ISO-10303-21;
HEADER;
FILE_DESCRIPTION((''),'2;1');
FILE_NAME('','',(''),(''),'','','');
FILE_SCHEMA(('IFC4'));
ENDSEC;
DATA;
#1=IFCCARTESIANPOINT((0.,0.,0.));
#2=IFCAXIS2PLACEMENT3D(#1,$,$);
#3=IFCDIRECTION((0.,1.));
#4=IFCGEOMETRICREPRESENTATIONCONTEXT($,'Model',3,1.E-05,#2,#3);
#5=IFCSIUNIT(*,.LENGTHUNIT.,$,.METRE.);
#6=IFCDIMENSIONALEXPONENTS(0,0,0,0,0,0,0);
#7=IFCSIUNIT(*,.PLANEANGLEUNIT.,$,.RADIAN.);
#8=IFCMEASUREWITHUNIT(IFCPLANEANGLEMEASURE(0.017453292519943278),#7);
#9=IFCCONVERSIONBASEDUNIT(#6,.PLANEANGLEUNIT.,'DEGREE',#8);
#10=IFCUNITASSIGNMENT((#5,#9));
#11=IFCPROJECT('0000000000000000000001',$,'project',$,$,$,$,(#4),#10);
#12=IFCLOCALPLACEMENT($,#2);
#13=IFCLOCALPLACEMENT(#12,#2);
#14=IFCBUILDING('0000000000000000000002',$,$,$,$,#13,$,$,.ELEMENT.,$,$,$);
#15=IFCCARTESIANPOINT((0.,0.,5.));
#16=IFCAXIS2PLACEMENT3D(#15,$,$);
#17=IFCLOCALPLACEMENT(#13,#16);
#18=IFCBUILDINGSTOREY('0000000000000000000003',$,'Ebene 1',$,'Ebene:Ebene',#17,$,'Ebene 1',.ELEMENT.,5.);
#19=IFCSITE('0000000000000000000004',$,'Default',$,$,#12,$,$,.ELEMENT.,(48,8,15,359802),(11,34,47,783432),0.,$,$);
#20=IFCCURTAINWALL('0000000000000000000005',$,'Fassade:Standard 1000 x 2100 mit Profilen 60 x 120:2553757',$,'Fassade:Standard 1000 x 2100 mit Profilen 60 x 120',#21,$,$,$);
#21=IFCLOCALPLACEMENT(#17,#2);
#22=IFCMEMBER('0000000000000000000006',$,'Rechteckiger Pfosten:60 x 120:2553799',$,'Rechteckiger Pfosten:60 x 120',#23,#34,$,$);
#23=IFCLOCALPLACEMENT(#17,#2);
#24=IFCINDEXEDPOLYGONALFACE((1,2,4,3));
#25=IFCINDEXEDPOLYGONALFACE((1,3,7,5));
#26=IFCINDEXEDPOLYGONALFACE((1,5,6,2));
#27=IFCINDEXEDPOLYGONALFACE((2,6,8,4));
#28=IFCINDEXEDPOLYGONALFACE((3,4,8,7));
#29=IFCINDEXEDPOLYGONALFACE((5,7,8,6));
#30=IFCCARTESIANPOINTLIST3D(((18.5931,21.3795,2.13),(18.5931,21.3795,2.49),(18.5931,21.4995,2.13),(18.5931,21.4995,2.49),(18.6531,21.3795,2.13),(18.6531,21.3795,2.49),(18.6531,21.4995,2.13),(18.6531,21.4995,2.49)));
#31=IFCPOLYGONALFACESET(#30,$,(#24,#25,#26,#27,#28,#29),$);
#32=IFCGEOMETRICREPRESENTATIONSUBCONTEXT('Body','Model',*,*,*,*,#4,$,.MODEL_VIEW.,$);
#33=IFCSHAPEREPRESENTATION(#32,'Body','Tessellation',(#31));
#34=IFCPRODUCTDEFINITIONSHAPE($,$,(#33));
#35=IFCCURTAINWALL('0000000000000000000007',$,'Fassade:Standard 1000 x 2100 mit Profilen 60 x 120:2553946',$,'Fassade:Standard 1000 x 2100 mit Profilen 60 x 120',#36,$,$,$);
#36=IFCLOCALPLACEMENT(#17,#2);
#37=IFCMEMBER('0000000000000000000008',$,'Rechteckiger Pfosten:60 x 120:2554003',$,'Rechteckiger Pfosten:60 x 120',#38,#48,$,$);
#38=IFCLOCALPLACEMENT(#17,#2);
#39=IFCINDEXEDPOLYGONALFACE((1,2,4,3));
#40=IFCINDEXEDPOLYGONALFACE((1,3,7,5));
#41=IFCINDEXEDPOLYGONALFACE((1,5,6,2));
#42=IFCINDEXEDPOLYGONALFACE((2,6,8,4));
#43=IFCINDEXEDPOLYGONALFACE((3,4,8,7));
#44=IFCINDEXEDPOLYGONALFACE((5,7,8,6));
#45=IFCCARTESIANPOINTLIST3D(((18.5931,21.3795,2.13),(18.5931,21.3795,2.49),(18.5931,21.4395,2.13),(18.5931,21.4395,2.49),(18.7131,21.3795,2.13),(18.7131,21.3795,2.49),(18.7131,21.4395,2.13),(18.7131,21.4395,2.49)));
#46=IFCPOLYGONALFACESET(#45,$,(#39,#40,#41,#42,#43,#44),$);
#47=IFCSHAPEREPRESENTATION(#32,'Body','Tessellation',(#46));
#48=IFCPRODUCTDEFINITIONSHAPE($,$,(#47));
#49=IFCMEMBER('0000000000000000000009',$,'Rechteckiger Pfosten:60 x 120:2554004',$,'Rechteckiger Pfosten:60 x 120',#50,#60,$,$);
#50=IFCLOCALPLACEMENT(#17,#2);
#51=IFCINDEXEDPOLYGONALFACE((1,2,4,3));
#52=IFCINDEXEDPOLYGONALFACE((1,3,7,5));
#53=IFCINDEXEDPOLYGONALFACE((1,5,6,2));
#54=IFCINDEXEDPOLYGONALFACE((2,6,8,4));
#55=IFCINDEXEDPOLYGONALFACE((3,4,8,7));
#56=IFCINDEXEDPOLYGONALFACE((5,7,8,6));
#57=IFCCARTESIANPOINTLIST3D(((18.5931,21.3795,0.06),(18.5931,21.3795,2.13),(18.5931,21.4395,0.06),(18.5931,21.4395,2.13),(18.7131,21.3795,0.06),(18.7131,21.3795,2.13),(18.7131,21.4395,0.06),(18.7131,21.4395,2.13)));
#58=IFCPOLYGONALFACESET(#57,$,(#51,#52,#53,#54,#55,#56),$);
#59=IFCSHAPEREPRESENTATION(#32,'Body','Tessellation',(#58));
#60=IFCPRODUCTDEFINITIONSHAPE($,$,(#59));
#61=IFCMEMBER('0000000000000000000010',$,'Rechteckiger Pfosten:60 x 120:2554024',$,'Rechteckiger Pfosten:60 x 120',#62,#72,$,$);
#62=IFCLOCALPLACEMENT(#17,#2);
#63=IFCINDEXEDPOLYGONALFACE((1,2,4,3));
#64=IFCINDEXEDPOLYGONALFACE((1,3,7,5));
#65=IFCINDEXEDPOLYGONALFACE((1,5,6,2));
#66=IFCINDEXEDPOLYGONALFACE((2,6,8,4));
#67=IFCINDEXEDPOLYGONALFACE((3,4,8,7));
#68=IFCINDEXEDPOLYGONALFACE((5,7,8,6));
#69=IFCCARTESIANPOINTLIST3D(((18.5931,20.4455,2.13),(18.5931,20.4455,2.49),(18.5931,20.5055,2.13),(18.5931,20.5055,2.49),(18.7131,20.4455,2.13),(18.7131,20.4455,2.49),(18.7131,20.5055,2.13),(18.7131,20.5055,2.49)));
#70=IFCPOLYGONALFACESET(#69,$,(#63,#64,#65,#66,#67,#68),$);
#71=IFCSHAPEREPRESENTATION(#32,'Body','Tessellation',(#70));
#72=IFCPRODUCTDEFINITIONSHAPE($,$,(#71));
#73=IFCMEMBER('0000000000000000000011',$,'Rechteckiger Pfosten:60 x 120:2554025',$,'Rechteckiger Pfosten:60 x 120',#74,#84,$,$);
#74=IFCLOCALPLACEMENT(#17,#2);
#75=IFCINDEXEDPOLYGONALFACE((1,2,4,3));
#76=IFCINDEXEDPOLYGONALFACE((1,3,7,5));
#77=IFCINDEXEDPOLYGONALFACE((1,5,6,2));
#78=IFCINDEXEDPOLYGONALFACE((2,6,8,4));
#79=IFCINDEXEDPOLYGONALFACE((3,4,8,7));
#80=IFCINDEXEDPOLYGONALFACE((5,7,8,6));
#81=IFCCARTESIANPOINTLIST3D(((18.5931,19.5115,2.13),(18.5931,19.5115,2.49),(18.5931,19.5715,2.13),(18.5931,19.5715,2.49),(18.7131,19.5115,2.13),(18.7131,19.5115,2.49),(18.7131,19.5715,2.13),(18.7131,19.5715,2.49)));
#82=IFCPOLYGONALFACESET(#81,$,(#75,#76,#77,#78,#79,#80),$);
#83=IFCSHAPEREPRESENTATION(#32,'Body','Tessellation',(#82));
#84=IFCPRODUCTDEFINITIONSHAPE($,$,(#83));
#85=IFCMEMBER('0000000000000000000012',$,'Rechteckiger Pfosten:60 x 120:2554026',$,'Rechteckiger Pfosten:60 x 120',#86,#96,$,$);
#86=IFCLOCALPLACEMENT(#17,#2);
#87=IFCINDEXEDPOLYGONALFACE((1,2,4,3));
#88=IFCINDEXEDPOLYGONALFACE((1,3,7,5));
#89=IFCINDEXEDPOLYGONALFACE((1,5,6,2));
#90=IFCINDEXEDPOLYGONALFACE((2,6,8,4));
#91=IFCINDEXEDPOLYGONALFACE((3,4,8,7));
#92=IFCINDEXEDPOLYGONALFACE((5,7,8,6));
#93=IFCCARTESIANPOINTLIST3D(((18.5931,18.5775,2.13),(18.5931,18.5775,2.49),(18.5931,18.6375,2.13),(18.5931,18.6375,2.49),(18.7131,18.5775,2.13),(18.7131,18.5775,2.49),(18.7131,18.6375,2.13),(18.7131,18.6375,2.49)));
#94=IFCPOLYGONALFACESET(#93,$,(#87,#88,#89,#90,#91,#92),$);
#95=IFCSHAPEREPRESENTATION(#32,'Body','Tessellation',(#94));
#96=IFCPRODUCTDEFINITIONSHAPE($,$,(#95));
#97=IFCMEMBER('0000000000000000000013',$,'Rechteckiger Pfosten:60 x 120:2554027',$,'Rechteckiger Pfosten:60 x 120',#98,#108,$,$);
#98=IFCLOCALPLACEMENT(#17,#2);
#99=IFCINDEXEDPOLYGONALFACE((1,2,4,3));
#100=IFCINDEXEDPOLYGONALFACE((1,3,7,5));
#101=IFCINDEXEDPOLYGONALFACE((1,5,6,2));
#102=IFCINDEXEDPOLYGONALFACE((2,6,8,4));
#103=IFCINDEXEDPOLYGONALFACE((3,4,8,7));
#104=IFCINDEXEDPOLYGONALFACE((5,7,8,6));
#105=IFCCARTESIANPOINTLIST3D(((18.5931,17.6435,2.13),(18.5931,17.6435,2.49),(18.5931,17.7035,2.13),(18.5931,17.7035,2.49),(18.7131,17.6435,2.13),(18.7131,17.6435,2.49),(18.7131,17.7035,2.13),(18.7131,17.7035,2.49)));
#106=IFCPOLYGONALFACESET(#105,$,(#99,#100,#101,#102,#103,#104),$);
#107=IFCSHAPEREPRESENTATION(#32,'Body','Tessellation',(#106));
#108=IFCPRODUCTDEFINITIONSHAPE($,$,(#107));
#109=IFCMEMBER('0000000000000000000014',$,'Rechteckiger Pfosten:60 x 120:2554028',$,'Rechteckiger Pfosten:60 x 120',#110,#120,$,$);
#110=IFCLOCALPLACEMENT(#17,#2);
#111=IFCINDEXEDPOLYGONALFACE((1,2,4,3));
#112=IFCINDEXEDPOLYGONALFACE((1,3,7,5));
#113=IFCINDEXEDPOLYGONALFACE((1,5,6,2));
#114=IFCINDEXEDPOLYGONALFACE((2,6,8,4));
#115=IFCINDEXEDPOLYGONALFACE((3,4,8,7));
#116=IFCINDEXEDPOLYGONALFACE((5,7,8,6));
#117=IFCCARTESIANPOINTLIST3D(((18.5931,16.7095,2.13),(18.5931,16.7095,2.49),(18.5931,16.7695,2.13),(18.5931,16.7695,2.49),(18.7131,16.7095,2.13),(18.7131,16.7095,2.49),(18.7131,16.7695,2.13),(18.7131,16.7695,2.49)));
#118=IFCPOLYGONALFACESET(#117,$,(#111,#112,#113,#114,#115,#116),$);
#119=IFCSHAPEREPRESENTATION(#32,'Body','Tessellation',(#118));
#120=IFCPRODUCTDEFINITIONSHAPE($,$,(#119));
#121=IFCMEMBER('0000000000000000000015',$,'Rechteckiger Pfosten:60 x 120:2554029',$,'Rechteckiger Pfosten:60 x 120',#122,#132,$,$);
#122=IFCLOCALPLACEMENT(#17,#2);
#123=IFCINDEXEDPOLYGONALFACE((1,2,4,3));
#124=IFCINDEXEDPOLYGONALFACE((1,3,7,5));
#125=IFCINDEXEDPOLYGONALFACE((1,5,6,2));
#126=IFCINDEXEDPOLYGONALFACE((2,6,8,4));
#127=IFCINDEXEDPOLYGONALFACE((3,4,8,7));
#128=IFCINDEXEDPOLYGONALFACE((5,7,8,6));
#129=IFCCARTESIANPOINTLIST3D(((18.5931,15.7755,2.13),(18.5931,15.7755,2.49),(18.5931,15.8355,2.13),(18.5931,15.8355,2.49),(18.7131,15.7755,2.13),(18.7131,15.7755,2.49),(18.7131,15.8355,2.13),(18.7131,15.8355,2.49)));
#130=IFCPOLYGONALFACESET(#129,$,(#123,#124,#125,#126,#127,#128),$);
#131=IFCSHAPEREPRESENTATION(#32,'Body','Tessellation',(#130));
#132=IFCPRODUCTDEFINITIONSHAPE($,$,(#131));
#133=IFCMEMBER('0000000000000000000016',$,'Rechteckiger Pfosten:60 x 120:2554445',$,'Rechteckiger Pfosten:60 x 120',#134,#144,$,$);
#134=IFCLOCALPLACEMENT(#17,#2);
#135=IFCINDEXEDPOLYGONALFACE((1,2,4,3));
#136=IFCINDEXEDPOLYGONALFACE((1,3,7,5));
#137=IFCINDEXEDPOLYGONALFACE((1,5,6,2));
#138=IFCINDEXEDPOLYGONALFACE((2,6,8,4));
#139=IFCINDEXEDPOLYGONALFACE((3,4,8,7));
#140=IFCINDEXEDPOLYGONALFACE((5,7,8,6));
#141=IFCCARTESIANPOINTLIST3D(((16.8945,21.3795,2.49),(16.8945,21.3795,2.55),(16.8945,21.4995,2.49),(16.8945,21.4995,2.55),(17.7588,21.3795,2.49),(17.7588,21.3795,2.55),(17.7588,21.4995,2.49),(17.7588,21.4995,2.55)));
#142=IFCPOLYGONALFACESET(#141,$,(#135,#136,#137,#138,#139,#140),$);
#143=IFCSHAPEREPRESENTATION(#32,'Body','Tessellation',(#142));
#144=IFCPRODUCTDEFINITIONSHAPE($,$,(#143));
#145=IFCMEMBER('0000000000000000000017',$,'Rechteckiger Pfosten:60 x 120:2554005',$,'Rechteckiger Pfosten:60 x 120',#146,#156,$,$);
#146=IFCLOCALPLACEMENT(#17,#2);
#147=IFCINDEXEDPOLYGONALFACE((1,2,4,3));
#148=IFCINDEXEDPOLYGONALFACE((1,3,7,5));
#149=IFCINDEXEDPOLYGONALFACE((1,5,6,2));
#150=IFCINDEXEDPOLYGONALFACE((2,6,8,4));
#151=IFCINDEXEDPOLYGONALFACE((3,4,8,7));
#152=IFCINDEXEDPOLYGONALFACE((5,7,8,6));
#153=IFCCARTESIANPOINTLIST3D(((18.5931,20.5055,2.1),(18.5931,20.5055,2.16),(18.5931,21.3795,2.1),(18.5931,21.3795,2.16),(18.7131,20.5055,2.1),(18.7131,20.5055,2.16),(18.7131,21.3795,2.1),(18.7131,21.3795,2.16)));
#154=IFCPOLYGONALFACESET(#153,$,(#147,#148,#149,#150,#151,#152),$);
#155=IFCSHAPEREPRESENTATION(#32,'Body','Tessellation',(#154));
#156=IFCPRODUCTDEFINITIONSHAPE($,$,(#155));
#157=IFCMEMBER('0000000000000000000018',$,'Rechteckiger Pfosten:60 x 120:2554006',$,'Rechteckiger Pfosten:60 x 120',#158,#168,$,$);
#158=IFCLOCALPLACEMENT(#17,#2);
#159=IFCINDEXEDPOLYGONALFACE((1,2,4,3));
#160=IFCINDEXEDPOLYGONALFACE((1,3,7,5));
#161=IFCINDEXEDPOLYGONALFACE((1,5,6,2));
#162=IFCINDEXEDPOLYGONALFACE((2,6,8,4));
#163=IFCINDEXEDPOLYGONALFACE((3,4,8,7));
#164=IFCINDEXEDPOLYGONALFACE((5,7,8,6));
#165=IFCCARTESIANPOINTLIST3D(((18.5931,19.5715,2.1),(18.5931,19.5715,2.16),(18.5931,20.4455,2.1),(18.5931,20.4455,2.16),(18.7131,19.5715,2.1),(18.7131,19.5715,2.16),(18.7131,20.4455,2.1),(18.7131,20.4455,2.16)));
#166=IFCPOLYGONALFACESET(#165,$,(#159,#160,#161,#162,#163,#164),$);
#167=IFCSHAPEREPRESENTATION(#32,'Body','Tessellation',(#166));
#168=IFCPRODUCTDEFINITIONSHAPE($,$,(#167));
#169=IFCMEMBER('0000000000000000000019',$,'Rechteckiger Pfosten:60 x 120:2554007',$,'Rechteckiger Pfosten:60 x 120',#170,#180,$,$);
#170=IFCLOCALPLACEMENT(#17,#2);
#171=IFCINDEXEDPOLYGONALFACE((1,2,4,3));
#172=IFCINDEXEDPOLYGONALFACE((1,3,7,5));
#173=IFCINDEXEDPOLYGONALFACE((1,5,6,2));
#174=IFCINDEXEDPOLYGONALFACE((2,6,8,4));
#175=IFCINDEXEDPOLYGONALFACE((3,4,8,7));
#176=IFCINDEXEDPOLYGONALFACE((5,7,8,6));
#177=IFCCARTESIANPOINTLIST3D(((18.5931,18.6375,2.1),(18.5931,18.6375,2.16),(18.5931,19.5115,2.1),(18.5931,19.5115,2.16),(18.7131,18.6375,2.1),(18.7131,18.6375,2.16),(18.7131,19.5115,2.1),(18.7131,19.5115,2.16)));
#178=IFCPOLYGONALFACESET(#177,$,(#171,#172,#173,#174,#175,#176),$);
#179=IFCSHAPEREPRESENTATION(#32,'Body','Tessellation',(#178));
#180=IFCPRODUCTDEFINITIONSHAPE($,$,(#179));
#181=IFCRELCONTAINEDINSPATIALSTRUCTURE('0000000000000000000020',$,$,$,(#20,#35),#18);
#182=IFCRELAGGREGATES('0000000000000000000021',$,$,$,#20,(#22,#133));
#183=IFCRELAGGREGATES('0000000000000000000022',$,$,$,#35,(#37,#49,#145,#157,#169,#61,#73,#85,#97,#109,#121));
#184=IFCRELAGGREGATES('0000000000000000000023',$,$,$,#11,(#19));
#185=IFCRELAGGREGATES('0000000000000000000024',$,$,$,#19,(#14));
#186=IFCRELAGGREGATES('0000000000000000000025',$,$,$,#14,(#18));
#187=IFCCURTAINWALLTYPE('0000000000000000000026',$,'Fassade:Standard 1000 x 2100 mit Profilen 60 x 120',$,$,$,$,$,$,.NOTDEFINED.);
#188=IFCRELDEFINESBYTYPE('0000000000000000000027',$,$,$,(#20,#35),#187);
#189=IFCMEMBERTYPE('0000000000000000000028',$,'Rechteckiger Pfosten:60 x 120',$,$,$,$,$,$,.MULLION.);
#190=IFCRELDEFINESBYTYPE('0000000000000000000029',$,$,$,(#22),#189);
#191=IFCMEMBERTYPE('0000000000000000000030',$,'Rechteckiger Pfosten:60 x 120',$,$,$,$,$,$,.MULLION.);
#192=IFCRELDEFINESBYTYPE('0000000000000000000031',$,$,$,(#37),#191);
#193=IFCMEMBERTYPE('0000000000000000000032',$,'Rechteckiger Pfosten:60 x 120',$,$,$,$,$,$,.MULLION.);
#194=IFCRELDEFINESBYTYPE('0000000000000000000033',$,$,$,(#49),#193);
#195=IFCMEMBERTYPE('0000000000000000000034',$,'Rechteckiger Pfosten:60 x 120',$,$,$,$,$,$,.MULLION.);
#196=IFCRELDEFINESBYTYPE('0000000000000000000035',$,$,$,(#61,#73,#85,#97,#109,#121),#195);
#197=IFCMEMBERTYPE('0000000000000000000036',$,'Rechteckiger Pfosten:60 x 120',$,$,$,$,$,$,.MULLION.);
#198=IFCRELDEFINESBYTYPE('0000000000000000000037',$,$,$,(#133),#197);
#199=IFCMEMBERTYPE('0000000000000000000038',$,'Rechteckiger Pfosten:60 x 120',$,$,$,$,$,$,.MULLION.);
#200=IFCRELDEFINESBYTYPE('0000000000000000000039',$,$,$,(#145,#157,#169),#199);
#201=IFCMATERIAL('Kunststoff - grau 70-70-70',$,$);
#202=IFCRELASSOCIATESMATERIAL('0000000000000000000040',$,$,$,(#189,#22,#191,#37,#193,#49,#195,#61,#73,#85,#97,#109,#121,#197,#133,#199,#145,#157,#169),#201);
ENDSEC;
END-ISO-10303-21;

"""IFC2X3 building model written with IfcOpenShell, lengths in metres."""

from ifc_helpers import new_model, entity, si_unit, converted_unit, direction, frame, frame_2d, origin, origin_2d_with_axis, place, context, subcontext, project, spatial, rectangle, extrude, source, transform, mapped, material, type_object, type_shapes, element, aggregate, save


model = new_model("IFC2X3")

# Units and contexts
model_context = context("Model", 3, precision=1e-05, world=origin(), true_north=direction((0.0, 1.0)))
body_context = subcontext(model_context, "Body", "Model", "MODEL_VIEW")
ifc_project = project(units=[si_unit("LENGTHUNIT", "METRE"), converted_unit("PLANEANGLEUNIT", "DEGREE", entity("IfcPlaneAngleMeasure", 0.017453292519943278), si_unit("PLANEANGLEUNIT", "RADIAN"), dimensions=[0, 0, 0, 0, 0, 0, 0])], contexts=[model_context])

# Site, building, storey
site_placement = place(None, origin())
site = spatial("IfcSite", under=ifc_project, at=site_placement, Name="Default", CompositionType="ELEMENT", RefLatitude=(48, 8, 15, 359802), RefLongitude=(11, 34, 47, 783432), RefElevation=0.0)
building_placement = place(site_placement, origin())
building = spatial("IfcBuilding", under=site, at=building_placement, CompositionType="ELEMENT")
storey_placement = place(building_placement, frame((0.0, 0.0, 5.0)))
storey = spatial("IfcBuildingStorey", under=building, at=storey_placement, Name="Ebene 1", ObjectType="Ebene:Ebene", LongName="Ebene 1", CompositionType="ELEMENT", Elevation=5.0)

# Curtain wall, member
curtain_wall_type = type_object("IfcCurtainWallType", Name="Fassade:Standard 1000 x 2100 mit Profilen 60 x 120", PredefinedType="NOTDEFINED")
curtain_wall_1_placement = place(storey_placement, frame((0.0, 0.0, -5.0)))
curtain_wall_1 = element("IfcCurtainWall", 1, at=curtain_wall_1_placement, inside=storey, type_object=curtain_wall_type, Name="Fassade:Standard 1000 x 2100 mit Profilen 60 x 120:2553757", ObjectType="Fassade:Standard 1000 x 2100 mit Profilen 60 x 120")
ifc_material_1 = material(Name="Kunststoff - grau 70-70-70")
member_type_1 = type_object("IfcMemberType", Name="Rechteckiger Pfosten:60 x 120", PredefinedType="MULLION", material=ifc_material_1)
shared_shape_1 = source(origin(), body_context, "Body", "SweptSolid", [
    extrude(rectangle(XDim=0.06, YDim=0.12, at=origin_2d_with_axis()), frame((-0.03, 0.0, -0.36), z_axis=(0.0, 0.0, 1.0), x_axis=(-1.0, 0.0, 0.0)), (0.0, 0.0, 1.0), 0.36),
])
type_shapes(member_type_1, [shared_shape_1])
member_1_placement = place(curtain_wall_1_placement, frame((18.6531, 21.4395, 7.13), z_axis=(0.0, 0.0, -1.0), x_axis=(1.0, 0.0, 0.0)))
member_1 = element("IfcMember", 2, at=member_1_placement, type_object=member_type_1, material=ifc_material_1, Name="Rechteckiger Pfosten:60 x 120:2553799", ObjectType="Rechteckiger Pfosten:60 x 120", context=body_context, shape_type="MappedRepresentation", body=[
    mapped(shared_shape_1, transform((0.0, 0.0, 0.0), scale=1.0)),
])

# Curtain wall, members
curtain_wall_2_placement = place(storey_placement, frame((0.0, 0.0, -5.0)))
curtain_wall_2 = element("IfcCurtainWall", 3, at=curtain_wall_2_placement, inside=storey, type_object=curtain_wall_type, Name="Fassade:Standard 1000 x 2100 mit Profilen 60 x 120:2553946", ObjectType="Fassade:Standard 1000 x 2100 mit Profilen 60 x 120")
member_type_2 = type_object("IfcMemberType", Name="Rechteckiger Pfosten:60 x 120", PredefinedType="MULLION", material=ifc_material_1)
shared_shape_2 = source(origin(), body_context, "Body", "SweptSolid", [
    extrude(rectangle(XDim=0.06, YDim=0.12, at=origin_2d_with_axis()), frame((-0.03, 0.0, -0.36), z_axis=(0.0, 0.0, 1.0), x_axis=(-1.0, 0.0, 0.0)), (0.0, 0.0, 1.0), 0.36),
])
type_shapes(member_type_2, [shared_shape_2])
member_2_placement = place(curtain_wall_2_placement, frame((18.6531, 21.4395, 7.49), z_axis=(0.0, 0.0, 1.0), x_axis=(0.0, 1.0, 0.0)))
member_2 = element("IfcMember", 4, at=member_2_placement, type_object=member_type_2, material=ifc_material_1, Name="Rechteckiger Pfosten:60 x 120:2554003", ObjectType="Rechteckiger Pfosten:60 x 120", context=body_context, shape_type="MappedRepresentation", body=[
    mapped(shared_shape_2, transform((0.0, 0.0, 0.0), scale=1.0)),
])
member_type_3 = type_object("IfcMemberType", Name="Rechteckiger Pfosten:60 x 120", PredefinedType="MULLION", material=ifc_material_1)
shared_shape_3 = source(origin(), body_context, "Body", "SweptSolid", [
    extrude(rectangle(XDim=0.06, YDim=0.12, at=origin_2d_with_axis()), frame((-0.03, 0.0, -2.07), z_axis=(0.0, 0.0, 1.0), x_axis=(-1.0, 0.0, 0.0)), (0.0, 0.0, 1.0), 2.07),
])
type_shapes(member_type_3, [shared_shape_3])
member_3_placement = place(curtain_wall_2_placement, frame((18.6531, 21.4395, 7.13), z_axis=(0.0, 0.0, 1.0), x_axis=(0.0, 1.0, 0.0)))
member_3 = element("IfcMember", 5, at=member_3_placement, type_object=member_type_3, material=ifc_material_1, Name="Rechteckiger Pfosten:60 x 120:2554004", ObjectType="Rechteckiger Pfosten:60 x 120", context=body_context, shape_type="MappedRepresentation", body=[
    mapped(shared_shape_3, transform((0.0, 0.0, 0.0), scale=1.0)),
])
member_type_4 = type_object("IfcMemberType", Name="Rechteckiger Pfosten:60 x 120", PredefinedType="MULLION", material=ifc_material_1)
shared_shape_4 = source(origin(), body_context, "Body", "SweptSolid", [
    extrude(rectangle(XDim=0.06, YDim=0.12, at=frame_2d((0.0, 0.0), x_axis=(1.0, 0.0))), frame((0.0, 0.0, -0.36), z_axis=(0.0, 0.0, 1.0), x_axis=(-1.0, 0.0, 0.0)), (0.0, 0.0, 1.0), 0.36),
])
type_shapes(member_type_4, [shared_shape_4])
member_4_placement = place(curtain_wall_2_placement, frame((18.6531, 20.4755, 7.13), z_axis=(0.0, 0.0, -1.0), x_axis=(0.0, -1.0, 0.0)))
member_4 = element("IfcMember", 6, at=member_4_placement, type_object=member_type_4, material=ifc_material_1, Name="Rechteckiger Pfosten:60 x 120:2554024", ObjectType="Rechteckiger Pfosten:60 x 120", context=body_context, shape_type="MappedRepresentation", body=[
    mapped(shared_shape_4, transform((0.0, 0.0, 0.0), scale=1.0)),
])
member_5_placement = place(curtain_wall_2_placement, frame((18.6531, 19.5415, 7.13), z_axis=(0.0, 0.0, -1.0), x_axis=(0.0, -1.0, 0.0)))
member_5 = element("IfcMember", 7, at=member_5_placement, type_object=member_type_4, material=ifc_material_1, Name="Rechteckiger Pfosten:60 x 120:2554025", ObjectType="Rechteckiger Pfosten:60 x 120", context=body_context, shape_type="MappedRepresentation", body=[
    mapped(shared_shape_4, transform((0.0, 0.0, 0.0), scale=1.0)),
])
member_6_placement = place(curtain_wall_2_placement, frame((18.6531, 18.6075, 7.13), z_axis=(0.0, 0.0, -1.0), x_axis=(0.0, -1.0, 0.0)))
member_6 = element("IfcMember", 8, at=member_6_placement, type_object=member_type_4, material=ifc_material_1, Name="Rechteckiger Pfosten:60 x 120:2554026", ObjectType="Rechteckiger Pfosten:60 x 120", context=body_context, shape_type="MappedRepresentation", body=[
    mapped(shared_shape_4, transform((0.0, 0.0, 0.0), scale=1.0)),
])
member_7_placement = place(curtain_wall_2_placement, frame((18.6531, 17.6735, 7.13), z_axis=(0.0, 0.0, -1.0), x_axis=(0.0, -1.0, 0.0)))
member_7 = element("IfcMember", 9, at=member_7_placement, type_object=member_type_4, material=ifc_material_1, Name="Rechteckiger Pfosten:60 x 120:2554027", ObjectType="Rechteckiger Pfosten:60 x 120", context=body_context, shape_type="MappedRepresentation", body=[
    mapped(shared_shape_4, transform((0.0, 0.0, 0.0), scale=1.0)),
])
member_8_placement = place(curtain_wall_2_placement, frame((18.6531, 16.7395, 7.13), z_axis=(0.0, 0.0, -1.0), x_axis=(0.0, -1.0, 0.0)))
member_8 = element("IfcMember", 10, at=member_8_placement, type_object=member_type_4, material=ifc_material_1, Name="Rechteckiger Pfosten:60 x 120:2554028", ObjectType="Rechteckiger Pfosten:60 x 120", context=body_context, shape_type="MappedRepresentation", body=[
    mapped(shared_shape_4, transform((0.0, 0.0, 0.0), scale=1.0)),
])
member_9_placement = place(curtain_wall_2_placement, frame((18.6531, 15.8055, 7.13), z_axis=(0.0, 0.0, -1.0), x_axis=(0.0, -1.0, 0.0)))
member_9 = element("IfcMember", 11, at=member_9_placement, type_object=member_type_4, material=ifc_material_1, Name="Rechteckiger Pfosten:60 x 120:2554029", ObjectType="Rechteckiger Pfosten:60 x 120", context=body_context, shape_type="MappedRepresentation", body=[
    mapped(shared_shape_4, transform((0.0, 0.0, 0.0), scale=1.0)),
])

# Members
member_type_5 = type_object("IfcMemberType", Name="Rechteckiger Pfosten:60 x 120", PredefinedType="MULLION", material=ifc_material_1)
shared_shape_5 = source(origin(), body_context, "Body", "SweptSolid", [
    extrude(rectangle(XDim=0.06, YDim=0.12, at=origin_2d_with_axis()), frame((-0.03, 0.0, -0.8643), z_axis=(0.0, 0.0, 1.0), x_axis=(-1.0, 0.0, 0.0)), (0.0, 0.0, 1.0), 0.8643),
])
type_shapes(member_type_5, [shared_shape_5])
member_10_placement = place(curtain_wall_1_placement, frame((17.7588, 21.4395, 7.55), z_axis=(1.0, 0.0, 0.0), x_axis=(0.0, 0.0, 1.0)))
member_10 = element("IfcMember", 12, at=member_10_placement, type_object=member_type_5, material=ifc_material_1, Name="Rechteckiger Pfosten:60 x 120:2554445", ObjectType="Rechteckiger Pfosten:60 x 120", context=body_context, shape_type="MappedRepresentation", body=[
    mapped(shared_shape_5, transform((0.0, 0.0, 0.0), scale=1.0)),
])
member_type_6 = type_object("IfcMemberType", Name="Rechteckiger Pfosten:60 x 120", PredefinedType="MULLION", material=ifc_material_1)
shared_shape_6 = source(origin(), body_context, "Body", "SweptSolid", [
    extrude(rectangle(XDim=0.06, YDim=0.12, at=frame_2d((0.0, 0.0), x_axis=(1.0, 0.0))), frame((0.0, 0.0, -0.874), z_axis=(0.0, 0.0, 1.0), x_axis=(-1.0, 0.0, 0.0)), (0.0, 0.0, 1.0), 0.874),
])
type_shapes(member_type_6, [shared_shape_6])
member_11_placement = place(curtain_wall_2_placement, frame((18.6531, 20.5055, 7.13), z_axis=(0.0, -1.0, 0.0), x_axis=(0.0, 0.0, 1.0)))
member_11 = element("IfcMember", 13, at=member_11_placement, type_object=member_type_6, material=ifc_material_1, Name="Rechteckiger Pfosten:60 x 120:2554005", ObjectType="Rechteckiger Pfosten:60 x 120", context=body_context, shape_type="MappedRepresentation", body=[
    mapped(shared_shape_6, transform((0.0, 0.0, 0.0), scale=1.0)),
])
member_12_placement = place(curtain_wall_2_placement, frame((18.6531, 19.5715, 7.13), z_axis=(0.0, -1.0, 0.0), x_axis=(0.0, 0.0, 1.0)))
member_12 = element("IfcMember", 14, at=member_12_placement, type_object=member_type_6, material=ifc_material_1, Name="Rechteckiger Pfosten:60 x 120:2554006", ObjectType="Rechteckiger Pfosten:60 x 120", context=body_context, shape_type="MappedRepresentation", body=[
    mapped(shared_shape_6, transform((0.0, 0.0, 0.0), scale=1.0)),
])
member_13_placement = place(curtain_wall_2_placement, frame((18.6531, 18.6375, 7.13), z_axis=(0.0, -1.0, 0.0), x_axis=(0.0, 0.0, 1.0)))
member_13 = element("IfcMember", 15, at=member_13_placement, type_object=member_type_6, material=ifc_material_1, Name="Rechteckiger Pfosten:60 x 120:2554007", ObjectType="Rechteckiger Pfosten:60 x 120", context=body_context, shape_type="MappedRepresentation", body=[
    mapped(shared_shape_6, transform((0.0, 0.0, 0.0), scale=1.0)),
])

aggregate(curtain_wall_1, [member_1, member_10])
aggregate(curtain_wall_2, [member_2, member_3, member_11, member_12, member_13, member_4, member_5, member_6, member_7, member_8, member_9])

save(model, "model.ifc")
